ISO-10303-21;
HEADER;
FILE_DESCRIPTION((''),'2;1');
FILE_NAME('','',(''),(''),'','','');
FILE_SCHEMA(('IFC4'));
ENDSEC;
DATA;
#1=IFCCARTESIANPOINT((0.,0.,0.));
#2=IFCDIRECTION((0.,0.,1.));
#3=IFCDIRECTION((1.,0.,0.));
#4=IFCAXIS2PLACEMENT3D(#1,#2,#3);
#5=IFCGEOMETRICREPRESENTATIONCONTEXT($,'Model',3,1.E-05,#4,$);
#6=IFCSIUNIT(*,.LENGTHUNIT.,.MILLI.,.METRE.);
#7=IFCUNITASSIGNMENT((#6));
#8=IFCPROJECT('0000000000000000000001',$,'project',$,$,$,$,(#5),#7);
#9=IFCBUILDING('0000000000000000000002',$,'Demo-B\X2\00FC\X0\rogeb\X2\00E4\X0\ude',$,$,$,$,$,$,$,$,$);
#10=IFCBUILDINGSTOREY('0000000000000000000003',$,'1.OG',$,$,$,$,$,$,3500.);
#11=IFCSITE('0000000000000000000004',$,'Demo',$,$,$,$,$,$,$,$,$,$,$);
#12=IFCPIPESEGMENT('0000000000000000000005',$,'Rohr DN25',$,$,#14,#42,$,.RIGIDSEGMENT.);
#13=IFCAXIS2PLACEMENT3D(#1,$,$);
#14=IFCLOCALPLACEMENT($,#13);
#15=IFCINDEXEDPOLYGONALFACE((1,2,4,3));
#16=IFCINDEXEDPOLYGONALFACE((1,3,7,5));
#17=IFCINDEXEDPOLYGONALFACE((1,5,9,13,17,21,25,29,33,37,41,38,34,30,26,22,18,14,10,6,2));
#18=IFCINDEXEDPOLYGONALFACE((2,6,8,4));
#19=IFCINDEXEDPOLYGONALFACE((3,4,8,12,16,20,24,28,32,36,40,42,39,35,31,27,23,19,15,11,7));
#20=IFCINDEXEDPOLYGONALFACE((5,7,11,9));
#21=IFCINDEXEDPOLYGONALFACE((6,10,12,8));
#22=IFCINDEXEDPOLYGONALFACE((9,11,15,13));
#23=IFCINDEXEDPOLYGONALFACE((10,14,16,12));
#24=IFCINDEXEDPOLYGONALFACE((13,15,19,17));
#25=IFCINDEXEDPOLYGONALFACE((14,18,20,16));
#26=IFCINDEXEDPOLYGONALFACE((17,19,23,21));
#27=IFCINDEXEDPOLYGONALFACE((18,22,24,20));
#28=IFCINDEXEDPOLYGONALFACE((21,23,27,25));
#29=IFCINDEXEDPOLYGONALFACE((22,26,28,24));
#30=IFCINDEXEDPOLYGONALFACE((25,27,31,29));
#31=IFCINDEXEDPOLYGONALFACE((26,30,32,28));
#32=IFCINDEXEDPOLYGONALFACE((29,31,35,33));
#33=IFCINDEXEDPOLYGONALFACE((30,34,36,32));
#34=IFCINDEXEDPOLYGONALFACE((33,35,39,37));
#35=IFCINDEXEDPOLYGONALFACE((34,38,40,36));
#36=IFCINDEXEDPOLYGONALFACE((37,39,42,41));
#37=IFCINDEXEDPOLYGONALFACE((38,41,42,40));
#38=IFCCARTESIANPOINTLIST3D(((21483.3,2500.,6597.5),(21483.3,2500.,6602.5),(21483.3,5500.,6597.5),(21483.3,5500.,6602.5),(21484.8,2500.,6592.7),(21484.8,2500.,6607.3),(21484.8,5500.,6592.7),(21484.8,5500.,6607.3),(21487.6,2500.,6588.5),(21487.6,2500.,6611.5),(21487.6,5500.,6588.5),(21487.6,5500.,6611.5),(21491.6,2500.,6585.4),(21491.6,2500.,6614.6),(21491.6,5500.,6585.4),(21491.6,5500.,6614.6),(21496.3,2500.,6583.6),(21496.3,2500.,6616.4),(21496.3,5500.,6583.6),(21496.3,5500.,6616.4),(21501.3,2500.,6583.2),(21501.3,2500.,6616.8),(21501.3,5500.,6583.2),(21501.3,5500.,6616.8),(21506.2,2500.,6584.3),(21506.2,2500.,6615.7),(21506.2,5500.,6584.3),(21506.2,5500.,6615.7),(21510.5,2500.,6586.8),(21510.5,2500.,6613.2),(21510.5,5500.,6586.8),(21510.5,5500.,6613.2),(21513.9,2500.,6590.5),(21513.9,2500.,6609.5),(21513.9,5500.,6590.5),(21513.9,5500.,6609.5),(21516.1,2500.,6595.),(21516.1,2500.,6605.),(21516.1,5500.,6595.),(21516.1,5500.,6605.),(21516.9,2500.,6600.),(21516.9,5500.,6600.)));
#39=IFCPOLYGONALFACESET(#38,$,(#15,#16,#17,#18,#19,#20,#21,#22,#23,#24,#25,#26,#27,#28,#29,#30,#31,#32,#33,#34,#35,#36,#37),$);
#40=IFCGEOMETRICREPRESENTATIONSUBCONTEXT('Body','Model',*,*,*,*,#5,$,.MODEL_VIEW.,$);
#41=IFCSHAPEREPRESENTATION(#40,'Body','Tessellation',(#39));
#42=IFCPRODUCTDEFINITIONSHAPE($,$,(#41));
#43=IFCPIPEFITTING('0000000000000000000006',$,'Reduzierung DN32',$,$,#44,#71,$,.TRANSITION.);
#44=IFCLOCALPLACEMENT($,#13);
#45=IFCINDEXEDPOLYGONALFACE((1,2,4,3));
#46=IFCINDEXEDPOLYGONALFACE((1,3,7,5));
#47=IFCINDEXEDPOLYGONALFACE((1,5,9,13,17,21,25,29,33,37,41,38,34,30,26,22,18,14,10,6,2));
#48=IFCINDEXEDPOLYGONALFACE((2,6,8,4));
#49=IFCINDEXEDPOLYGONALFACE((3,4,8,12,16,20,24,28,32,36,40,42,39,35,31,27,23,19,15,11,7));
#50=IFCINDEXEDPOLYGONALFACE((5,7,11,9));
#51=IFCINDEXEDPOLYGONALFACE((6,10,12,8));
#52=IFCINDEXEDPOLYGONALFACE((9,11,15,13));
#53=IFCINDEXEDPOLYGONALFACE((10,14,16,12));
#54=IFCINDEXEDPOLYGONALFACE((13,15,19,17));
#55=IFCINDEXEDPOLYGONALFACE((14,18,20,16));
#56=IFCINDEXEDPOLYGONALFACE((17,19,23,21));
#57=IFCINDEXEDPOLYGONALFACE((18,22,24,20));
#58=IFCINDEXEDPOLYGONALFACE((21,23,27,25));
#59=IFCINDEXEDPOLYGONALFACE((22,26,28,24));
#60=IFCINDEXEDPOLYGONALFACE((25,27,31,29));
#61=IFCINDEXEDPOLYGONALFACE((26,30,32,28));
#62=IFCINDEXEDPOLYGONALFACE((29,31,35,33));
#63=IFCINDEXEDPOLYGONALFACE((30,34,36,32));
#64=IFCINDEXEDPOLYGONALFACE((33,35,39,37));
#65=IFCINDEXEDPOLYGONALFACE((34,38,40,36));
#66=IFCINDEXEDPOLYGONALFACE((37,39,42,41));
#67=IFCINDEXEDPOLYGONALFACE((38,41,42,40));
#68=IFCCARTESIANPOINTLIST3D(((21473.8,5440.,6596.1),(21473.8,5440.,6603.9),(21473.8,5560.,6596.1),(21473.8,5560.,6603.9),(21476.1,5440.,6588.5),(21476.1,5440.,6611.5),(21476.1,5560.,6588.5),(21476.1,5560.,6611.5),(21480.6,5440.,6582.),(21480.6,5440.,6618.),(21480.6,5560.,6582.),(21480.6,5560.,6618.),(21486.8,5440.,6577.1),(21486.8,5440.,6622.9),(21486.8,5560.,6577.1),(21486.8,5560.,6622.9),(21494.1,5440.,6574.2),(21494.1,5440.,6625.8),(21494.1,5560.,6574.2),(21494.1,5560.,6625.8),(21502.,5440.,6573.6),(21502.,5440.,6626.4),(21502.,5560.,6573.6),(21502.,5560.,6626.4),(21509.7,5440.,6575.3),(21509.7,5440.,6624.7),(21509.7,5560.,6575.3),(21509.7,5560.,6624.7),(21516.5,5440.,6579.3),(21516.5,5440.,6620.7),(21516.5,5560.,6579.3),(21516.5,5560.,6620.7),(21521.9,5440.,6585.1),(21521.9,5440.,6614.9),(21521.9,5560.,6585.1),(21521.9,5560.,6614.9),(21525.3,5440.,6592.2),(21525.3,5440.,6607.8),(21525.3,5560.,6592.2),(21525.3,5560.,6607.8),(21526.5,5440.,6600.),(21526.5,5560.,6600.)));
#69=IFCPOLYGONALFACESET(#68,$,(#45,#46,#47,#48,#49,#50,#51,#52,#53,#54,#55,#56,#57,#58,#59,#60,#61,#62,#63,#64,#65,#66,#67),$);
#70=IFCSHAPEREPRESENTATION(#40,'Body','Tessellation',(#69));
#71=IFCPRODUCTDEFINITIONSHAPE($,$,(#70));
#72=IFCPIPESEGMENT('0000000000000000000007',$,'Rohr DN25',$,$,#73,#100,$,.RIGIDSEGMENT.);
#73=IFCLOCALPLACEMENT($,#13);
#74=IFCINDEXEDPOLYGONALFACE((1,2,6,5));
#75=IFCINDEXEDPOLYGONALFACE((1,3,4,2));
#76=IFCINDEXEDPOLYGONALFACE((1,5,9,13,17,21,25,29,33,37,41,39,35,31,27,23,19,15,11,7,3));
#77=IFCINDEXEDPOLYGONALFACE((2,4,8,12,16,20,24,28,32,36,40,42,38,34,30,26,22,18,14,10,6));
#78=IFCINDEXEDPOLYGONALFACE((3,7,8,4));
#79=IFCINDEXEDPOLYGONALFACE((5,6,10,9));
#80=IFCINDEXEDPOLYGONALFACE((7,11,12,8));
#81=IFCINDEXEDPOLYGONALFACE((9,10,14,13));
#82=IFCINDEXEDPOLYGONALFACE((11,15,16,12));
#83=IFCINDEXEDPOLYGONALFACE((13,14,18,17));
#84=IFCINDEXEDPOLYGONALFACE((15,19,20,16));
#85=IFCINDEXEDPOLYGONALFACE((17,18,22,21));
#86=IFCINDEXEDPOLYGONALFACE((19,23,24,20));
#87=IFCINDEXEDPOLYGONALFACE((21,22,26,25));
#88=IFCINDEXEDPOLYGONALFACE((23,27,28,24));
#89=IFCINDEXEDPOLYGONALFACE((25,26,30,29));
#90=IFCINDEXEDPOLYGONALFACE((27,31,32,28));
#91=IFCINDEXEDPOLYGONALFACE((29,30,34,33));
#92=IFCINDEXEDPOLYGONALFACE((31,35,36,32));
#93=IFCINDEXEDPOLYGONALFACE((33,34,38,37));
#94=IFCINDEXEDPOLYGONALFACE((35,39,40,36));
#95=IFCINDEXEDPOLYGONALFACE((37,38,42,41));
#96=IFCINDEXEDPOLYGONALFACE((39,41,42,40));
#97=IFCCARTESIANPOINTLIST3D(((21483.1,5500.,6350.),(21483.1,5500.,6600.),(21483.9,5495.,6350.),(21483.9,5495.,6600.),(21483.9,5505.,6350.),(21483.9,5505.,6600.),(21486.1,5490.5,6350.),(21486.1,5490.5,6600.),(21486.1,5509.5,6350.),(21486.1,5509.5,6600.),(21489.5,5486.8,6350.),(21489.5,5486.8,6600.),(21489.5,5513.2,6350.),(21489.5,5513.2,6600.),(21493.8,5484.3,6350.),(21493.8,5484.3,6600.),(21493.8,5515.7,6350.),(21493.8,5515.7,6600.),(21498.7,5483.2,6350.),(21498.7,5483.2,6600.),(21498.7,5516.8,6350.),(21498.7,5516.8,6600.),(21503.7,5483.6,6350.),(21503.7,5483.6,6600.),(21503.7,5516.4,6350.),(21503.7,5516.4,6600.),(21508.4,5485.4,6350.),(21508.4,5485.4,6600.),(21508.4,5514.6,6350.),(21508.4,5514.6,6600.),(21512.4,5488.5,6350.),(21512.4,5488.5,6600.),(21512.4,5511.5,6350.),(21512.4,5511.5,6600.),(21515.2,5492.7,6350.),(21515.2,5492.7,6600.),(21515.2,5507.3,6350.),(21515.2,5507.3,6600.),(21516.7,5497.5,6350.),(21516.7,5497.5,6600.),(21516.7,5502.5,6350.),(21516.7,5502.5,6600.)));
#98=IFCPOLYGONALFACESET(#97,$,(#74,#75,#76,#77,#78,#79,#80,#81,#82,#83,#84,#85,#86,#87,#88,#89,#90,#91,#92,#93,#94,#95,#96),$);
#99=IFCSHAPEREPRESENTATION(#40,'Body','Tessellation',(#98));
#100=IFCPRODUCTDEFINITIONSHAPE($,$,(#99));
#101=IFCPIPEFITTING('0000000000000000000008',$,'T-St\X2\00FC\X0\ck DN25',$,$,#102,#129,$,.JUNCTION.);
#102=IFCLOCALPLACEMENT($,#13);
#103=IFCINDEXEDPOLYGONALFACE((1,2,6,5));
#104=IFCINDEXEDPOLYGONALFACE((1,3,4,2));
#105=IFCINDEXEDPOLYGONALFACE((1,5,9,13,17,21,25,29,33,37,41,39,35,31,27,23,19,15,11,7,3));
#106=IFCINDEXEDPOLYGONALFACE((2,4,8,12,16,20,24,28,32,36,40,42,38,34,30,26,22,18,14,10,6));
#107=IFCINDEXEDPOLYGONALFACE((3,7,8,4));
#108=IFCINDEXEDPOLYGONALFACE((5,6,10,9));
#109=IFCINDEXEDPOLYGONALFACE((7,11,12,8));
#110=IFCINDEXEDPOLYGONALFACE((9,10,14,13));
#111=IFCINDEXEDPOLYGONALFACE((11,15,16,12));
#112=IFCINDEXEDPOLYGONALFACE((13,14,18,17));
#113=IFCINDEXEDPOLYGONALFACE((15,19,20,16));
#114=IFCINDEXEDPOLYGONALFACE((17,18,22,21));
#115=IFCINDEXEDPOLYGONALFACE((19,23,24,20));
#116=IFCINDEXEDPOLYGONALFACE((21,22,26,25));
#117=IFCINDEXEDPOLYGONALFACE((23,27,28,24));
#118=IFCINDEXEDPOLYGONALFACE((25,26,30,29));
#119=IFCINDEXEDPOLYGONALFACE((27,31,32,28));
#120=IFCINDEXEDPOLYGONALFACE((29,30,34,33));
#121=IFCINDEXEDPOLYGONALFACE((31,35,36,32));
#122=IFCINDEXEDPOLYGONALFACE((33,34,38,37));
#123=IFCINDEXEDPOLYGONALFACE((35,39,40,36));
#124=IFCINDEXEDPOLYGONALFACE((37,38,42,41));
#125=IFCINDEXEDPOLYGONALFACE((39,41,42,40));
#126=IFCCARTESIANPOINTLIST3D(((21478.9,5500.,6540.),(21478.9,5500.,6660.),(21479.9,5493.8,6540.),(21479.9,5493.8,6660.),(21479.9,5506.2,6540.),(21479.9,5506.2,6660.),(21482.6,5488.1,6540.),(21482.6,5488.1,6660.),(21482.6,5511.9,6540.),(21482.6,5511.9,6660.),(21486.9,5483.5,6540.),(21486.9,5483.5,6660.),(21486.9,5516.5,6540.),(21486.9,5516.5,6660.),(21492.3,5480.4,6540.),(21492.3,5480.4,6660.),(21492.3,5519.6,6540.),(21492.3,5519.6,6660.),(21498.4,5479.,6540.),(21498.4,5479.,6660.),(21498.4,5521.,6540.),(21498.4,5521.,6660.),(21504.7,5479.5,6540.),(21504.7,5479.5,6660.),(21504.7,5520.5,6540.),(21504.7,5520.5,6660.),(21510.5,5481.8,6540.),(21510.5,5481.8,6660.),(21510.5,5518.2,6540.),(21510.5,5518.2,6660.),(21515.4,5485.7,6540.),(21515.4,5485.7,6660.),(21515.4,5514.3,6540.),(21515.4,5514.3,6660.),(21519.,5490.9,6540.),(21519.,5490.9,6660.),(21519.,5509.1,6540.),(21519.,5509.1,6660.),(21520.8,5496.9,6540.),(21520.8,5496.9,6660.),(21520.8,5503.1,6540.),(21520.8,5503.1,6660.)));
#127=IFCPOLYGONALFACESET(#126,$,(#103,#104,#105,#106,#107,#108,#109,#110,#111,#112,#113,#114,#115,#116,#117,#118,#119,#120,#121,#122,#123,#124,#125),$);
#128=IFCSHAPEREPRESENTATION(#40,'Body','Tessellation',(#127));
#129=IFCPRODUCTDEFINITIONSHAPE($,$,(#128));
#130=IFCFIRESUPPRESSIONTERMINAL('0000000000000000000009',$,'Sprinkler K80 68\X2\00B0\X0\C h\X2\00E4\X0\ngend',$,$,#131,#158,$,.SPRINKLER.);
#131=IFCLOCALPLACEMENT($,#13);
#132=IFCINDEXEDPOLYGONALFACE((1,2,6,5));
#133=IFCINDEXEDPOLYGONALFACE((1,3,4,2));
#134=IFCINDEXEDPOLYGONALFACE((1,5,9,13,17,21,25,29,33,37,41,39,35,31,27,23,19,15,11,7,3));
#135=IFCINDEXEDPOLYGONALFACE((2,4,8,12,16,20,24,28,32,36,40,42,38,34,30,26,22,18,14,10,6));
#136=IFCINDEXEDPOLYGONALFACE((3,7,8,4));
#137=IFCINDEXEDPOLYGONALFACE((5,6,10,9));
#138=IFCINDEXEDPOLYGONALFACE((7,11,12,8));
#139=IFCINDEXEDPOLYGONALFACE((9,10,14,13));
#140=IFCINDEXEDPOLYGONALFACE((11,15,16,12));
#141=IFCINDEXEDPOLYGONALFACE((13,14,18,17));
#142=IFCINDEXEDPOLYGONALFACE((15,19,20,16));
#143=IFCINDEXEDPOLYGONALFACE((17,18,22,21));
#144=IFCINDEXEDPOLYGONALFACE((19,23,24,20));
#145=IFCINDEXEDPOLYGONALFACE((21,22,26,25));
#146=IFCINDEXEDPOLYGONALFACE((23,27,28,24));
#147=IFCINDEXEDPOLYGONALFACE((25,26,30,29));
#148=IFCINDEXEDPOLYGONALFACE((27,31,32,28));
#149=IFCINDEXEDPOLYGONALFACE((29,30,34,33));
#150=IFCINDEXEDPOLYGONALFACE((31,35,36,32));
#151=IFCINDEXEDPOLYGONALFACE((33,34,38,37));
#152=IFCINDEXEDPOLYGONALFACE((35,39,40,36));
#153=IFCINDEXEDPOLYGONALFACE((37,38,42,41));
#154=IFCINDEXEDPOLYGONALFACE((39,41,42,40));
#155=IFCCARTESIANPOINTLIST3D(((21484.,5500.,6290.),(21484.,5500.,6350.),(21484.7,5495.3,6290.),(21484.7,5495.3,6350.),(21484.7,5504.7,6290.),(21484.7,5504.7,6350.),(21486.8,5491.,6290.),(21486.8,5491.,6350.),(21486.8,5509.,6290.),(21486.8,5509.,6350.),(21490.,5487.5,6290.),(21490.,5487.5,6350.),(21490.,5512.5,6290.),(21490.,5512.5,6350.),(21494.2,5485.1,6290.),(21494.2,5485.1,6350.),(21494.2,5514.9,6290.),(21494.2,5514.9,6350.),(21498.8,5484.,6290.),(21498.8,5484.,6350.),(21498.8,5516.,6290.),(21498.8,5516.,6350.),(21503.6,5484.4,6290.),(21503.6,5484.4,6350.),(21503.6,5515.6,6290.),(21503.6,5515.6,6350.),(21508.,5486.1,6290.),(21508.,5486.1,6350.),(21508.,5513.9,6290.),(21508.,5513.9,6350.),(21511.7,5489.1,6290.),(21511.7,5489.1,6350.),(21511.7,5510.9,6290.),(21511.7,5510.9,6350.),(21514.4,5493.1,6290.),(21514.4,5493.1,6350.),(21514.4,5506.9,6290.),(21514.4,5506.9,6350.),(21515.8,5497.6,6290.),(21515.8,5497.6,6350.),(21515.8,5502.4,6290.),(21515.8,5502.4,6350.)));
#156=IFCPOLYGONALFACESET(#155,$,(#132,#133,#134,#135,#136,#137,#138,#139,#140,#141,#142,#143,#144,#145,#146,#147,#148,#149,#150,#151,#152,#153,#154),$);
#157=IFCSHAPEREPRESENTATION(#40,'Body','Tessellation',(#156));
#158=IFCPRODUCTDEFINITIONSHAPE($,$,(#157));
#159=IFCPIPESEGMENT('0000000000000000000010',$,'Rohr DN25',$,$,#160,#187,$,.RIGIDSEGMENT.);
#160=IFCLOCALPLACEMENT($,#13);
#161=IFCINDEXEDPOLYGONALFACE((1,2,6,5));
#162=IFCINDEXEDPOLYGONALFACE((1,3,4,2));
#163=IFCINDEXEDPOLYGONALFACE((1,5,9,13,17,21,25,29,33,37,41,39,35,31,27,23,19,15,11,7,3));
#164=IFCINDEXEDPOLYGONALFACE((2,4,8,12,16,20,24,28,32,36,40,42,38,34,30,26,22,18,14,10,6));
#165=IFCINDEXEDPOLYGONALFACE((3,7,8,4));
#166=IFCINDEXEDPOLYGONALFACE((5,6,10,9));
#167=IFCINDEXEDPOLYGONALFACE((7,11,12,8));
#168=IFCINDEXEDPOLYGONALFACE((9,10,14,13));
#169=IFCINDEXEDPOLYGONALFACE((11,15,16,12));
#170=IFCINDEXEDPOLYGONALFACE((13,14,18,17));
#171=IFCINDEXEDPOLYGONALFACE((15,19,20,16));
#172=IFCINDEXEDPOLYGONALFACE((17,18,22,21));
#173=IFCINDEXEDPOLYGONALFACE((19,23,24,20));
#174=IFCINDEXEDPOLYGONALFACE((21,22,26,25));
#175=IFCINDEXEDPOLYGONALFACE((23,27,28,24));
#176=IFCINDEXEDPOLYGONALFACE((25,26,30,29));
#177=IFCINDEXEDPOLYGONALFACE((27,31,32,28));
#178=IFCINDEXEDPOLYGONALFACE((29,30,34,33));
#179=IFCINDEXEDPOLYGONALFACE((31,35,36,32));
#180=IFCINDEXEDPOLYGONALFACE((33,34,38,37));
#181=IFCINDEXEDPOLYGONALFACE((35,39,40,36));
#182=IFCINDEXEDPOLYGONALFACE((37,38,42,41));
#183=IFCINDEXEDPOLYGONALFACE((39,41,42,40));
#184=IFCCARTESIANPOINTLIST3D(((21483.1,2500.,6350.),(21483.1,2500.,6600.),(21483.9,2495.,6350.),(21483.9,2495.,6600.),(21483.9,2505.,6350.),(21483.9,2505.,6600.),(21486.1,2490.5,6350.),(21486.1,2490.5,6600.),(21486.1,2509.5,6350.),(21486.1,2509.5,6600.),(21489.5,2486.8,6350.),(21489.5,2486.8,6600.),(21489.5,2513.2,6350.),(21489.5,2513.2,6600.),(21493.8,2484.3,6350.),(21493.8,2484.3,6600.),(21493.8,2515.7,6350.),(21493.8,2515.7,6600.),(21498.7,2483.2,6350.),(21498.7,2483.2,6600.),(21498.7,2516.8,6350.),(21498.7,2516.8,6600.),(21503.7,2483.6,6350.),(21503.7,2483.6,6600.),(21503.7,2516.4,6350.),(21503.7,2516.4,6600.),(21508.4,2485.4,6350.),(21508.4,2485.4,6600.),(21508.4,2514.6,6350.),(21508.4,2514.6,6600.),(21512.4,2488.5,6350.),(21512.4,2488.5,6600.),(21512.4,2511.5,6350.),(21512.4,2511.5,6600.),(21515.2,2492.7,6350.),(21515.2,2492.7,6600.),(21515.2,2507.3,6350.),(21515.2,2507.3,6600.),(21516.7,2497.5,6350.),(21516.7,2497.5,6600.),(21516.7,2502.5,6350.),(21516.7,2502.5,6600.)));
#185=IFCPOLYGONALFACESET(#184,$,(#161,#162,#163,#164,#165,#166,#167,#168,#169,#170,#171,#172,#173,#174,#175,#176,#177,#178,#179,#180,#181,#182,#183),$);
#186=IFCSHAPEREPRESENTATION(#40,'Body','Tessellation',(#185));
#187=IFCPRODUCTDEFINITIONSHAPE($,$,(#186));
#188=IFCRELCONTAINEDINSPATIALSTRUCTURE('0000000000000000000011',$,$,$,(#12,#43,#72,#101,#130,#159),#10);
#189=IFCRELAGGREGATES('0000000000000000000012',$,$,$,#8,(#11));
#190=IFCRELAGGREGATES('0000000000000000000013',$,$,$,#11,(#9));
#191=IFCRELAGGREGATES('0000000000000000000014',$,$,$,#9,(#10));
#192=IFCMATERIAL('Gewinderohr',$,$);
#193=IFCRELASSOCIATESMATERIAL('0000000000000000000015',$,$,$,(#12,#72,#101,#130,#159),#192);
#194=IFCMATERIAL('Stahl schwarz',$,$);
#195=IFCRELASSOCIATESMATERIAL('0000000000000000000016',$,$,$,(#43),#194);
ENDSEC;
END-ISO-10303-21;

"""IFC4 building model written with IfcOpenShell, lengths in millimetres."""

from ifc_helpers import new_model, si_unit, frame, origin_with_axes, place, context, subcontext, project, spatial, circle, extrude, material, element, save


model = new_model("IFC4")

# Units and contexts
model_context = context("Model", 3, precision=1e-05, world=origin_with_axes())
body_context = subcontext(model_context, "Body", "Model", "MODEL_VIEW")
ifc_project = project(units=[si_unit("LENGTHUNIT", "METRE", prefix="MILLI")], contexts=[model_context])

# Site, building, storey
site = spatial("IfcSite", under=ifc_project, Name="Demo")
building = spatial("IfcBuilding", under=site, Name="Demo-Bürogebäude")
storey = spatial("IfcBuildingStorey", under=building, Name="1.OG", Elevation=3500.0)

# Pipe segment
ifc_material_1 = material(Name="Gewinderohr")
pipe_segment_1_placement = place(None, frame((21500.0, 5500.0, 6600.0), z_axis=(0.0, -1.0, 0.0), x_axis=(1.0, 0.0, 0.0)))
element("IfcPipeSegment", 1, at=pipe_segment_1_placement, inside=storey, material=ifc_material_1, Name="Rohr DN25", PredefinedType="RIGIDSEGMENT", context=body_context, shape_type="SweptSolid", body=[
    extrude(circle(Radius=16.9), origin_with_axes(), (0.0, 0.0, 1.0), 3000.0),
])

# Pipe fitting
ifc_material_2 = material(Name="Stahl schwarz")
pipe_fitting_1_placement = place(None, frame((21500.0, 5560.0, 6600.0), z_axis=(0.0, -1.0, 0.0), x_axis=(1.0, 0.0, 0.0)))
element("IfcPipeFitting", 2, at=pipe_fitting_1_placement, inside=storey, material=ifc_material_2, Name="Reduzierung DN32", PredefinedType="TRANSITION", context=body_context, shape_type="SweptSolid", body=[
    extrude(circle(Radius=26.5), origin_with_axes(), (0.0, 0.0, 1.0), 120.0),
])

# Pipe segment
pipe_segment_2_placement = place(None, frame((21500.0, 5500.0, 6600.0), z_axis=(0.0, 0.0, -1.0), x_axis=(-1.0, 0.0, 0.0)))
element("IfcPipeSegment", 3, at=pipe_segment_2_placement, inside=storey, material=ifc_material_1, Name="Rohr DN25", PredefinedType="RIGIDSEGMENT", context=body_context, shape_type="SweptSolid", body=[
    extrude(circle(Radius=16.9), origin_with_axes(), (0.0, 0.0, 1.0), 250.0),
])

# Pipe fitting
pipe_fitting_2_placement = place(None, frame((21500.0, 5500.0, 6660.0), z_axis=(0.0, 0.0, -1.0), x_axis=(-1.0, 0.0, 0.0)))
element("IfcPipeFitting", 4, at=pipe_fitting_2_placement, inside=storey, material=ifc_material_1, Name="T-Stück DN25", PredefinedType="JUNCTION", context=body_context, shape_type="SweptSolid", body=[
    extrude(circle(Radius=21.1), origin_with_axes(), (0.0, 0.0, 1.0), 120.0),
])

# Fire suppression terminal
fire_suppression_terminal_1_placement = place(None, frame((21500.0, 5500.0, 6350.0), z_axis=(0.0, 0.0, -1.0), x_axis=(-1.0, 0.0, 0.0)))
element("IfcFireSuppressionTerminal", 5, at=fire_suppression_terminal_1_placement, inside=storey, material=ifc_material_1, Name="Sprinkler K80 68°C hängend", PredefinedType="SPRINKLER", context=body_context, shape_type="SweptSolid", body=[
    extrude(circle(Radius=16.0), origin_with_axes(), (0.0, 0.0, 1.0), 60.0),
])

# Pipe segment
pipe_segment_3_placement = place(None, frame((21500.0, 2500.0, 6600.0), z_axis=(0.0, 0.0, -1.0), x_axis=(-1.0, 0.0, 0.0)))
element("IfcPipeSegment", 6, at=pipe_segment_3_placement, inside=storey, material=ifc_material_1, Name="Rohr DN25", PredefinedType="RIGIDSEGMENT", context=body_context, shape_type="SweptSolid", body=[
    extrude(circle(Radius=16.9), origin_with_axes(), (0.0, 0.0, 1.0), 250.0),
])

save(model, "model.ifc")
